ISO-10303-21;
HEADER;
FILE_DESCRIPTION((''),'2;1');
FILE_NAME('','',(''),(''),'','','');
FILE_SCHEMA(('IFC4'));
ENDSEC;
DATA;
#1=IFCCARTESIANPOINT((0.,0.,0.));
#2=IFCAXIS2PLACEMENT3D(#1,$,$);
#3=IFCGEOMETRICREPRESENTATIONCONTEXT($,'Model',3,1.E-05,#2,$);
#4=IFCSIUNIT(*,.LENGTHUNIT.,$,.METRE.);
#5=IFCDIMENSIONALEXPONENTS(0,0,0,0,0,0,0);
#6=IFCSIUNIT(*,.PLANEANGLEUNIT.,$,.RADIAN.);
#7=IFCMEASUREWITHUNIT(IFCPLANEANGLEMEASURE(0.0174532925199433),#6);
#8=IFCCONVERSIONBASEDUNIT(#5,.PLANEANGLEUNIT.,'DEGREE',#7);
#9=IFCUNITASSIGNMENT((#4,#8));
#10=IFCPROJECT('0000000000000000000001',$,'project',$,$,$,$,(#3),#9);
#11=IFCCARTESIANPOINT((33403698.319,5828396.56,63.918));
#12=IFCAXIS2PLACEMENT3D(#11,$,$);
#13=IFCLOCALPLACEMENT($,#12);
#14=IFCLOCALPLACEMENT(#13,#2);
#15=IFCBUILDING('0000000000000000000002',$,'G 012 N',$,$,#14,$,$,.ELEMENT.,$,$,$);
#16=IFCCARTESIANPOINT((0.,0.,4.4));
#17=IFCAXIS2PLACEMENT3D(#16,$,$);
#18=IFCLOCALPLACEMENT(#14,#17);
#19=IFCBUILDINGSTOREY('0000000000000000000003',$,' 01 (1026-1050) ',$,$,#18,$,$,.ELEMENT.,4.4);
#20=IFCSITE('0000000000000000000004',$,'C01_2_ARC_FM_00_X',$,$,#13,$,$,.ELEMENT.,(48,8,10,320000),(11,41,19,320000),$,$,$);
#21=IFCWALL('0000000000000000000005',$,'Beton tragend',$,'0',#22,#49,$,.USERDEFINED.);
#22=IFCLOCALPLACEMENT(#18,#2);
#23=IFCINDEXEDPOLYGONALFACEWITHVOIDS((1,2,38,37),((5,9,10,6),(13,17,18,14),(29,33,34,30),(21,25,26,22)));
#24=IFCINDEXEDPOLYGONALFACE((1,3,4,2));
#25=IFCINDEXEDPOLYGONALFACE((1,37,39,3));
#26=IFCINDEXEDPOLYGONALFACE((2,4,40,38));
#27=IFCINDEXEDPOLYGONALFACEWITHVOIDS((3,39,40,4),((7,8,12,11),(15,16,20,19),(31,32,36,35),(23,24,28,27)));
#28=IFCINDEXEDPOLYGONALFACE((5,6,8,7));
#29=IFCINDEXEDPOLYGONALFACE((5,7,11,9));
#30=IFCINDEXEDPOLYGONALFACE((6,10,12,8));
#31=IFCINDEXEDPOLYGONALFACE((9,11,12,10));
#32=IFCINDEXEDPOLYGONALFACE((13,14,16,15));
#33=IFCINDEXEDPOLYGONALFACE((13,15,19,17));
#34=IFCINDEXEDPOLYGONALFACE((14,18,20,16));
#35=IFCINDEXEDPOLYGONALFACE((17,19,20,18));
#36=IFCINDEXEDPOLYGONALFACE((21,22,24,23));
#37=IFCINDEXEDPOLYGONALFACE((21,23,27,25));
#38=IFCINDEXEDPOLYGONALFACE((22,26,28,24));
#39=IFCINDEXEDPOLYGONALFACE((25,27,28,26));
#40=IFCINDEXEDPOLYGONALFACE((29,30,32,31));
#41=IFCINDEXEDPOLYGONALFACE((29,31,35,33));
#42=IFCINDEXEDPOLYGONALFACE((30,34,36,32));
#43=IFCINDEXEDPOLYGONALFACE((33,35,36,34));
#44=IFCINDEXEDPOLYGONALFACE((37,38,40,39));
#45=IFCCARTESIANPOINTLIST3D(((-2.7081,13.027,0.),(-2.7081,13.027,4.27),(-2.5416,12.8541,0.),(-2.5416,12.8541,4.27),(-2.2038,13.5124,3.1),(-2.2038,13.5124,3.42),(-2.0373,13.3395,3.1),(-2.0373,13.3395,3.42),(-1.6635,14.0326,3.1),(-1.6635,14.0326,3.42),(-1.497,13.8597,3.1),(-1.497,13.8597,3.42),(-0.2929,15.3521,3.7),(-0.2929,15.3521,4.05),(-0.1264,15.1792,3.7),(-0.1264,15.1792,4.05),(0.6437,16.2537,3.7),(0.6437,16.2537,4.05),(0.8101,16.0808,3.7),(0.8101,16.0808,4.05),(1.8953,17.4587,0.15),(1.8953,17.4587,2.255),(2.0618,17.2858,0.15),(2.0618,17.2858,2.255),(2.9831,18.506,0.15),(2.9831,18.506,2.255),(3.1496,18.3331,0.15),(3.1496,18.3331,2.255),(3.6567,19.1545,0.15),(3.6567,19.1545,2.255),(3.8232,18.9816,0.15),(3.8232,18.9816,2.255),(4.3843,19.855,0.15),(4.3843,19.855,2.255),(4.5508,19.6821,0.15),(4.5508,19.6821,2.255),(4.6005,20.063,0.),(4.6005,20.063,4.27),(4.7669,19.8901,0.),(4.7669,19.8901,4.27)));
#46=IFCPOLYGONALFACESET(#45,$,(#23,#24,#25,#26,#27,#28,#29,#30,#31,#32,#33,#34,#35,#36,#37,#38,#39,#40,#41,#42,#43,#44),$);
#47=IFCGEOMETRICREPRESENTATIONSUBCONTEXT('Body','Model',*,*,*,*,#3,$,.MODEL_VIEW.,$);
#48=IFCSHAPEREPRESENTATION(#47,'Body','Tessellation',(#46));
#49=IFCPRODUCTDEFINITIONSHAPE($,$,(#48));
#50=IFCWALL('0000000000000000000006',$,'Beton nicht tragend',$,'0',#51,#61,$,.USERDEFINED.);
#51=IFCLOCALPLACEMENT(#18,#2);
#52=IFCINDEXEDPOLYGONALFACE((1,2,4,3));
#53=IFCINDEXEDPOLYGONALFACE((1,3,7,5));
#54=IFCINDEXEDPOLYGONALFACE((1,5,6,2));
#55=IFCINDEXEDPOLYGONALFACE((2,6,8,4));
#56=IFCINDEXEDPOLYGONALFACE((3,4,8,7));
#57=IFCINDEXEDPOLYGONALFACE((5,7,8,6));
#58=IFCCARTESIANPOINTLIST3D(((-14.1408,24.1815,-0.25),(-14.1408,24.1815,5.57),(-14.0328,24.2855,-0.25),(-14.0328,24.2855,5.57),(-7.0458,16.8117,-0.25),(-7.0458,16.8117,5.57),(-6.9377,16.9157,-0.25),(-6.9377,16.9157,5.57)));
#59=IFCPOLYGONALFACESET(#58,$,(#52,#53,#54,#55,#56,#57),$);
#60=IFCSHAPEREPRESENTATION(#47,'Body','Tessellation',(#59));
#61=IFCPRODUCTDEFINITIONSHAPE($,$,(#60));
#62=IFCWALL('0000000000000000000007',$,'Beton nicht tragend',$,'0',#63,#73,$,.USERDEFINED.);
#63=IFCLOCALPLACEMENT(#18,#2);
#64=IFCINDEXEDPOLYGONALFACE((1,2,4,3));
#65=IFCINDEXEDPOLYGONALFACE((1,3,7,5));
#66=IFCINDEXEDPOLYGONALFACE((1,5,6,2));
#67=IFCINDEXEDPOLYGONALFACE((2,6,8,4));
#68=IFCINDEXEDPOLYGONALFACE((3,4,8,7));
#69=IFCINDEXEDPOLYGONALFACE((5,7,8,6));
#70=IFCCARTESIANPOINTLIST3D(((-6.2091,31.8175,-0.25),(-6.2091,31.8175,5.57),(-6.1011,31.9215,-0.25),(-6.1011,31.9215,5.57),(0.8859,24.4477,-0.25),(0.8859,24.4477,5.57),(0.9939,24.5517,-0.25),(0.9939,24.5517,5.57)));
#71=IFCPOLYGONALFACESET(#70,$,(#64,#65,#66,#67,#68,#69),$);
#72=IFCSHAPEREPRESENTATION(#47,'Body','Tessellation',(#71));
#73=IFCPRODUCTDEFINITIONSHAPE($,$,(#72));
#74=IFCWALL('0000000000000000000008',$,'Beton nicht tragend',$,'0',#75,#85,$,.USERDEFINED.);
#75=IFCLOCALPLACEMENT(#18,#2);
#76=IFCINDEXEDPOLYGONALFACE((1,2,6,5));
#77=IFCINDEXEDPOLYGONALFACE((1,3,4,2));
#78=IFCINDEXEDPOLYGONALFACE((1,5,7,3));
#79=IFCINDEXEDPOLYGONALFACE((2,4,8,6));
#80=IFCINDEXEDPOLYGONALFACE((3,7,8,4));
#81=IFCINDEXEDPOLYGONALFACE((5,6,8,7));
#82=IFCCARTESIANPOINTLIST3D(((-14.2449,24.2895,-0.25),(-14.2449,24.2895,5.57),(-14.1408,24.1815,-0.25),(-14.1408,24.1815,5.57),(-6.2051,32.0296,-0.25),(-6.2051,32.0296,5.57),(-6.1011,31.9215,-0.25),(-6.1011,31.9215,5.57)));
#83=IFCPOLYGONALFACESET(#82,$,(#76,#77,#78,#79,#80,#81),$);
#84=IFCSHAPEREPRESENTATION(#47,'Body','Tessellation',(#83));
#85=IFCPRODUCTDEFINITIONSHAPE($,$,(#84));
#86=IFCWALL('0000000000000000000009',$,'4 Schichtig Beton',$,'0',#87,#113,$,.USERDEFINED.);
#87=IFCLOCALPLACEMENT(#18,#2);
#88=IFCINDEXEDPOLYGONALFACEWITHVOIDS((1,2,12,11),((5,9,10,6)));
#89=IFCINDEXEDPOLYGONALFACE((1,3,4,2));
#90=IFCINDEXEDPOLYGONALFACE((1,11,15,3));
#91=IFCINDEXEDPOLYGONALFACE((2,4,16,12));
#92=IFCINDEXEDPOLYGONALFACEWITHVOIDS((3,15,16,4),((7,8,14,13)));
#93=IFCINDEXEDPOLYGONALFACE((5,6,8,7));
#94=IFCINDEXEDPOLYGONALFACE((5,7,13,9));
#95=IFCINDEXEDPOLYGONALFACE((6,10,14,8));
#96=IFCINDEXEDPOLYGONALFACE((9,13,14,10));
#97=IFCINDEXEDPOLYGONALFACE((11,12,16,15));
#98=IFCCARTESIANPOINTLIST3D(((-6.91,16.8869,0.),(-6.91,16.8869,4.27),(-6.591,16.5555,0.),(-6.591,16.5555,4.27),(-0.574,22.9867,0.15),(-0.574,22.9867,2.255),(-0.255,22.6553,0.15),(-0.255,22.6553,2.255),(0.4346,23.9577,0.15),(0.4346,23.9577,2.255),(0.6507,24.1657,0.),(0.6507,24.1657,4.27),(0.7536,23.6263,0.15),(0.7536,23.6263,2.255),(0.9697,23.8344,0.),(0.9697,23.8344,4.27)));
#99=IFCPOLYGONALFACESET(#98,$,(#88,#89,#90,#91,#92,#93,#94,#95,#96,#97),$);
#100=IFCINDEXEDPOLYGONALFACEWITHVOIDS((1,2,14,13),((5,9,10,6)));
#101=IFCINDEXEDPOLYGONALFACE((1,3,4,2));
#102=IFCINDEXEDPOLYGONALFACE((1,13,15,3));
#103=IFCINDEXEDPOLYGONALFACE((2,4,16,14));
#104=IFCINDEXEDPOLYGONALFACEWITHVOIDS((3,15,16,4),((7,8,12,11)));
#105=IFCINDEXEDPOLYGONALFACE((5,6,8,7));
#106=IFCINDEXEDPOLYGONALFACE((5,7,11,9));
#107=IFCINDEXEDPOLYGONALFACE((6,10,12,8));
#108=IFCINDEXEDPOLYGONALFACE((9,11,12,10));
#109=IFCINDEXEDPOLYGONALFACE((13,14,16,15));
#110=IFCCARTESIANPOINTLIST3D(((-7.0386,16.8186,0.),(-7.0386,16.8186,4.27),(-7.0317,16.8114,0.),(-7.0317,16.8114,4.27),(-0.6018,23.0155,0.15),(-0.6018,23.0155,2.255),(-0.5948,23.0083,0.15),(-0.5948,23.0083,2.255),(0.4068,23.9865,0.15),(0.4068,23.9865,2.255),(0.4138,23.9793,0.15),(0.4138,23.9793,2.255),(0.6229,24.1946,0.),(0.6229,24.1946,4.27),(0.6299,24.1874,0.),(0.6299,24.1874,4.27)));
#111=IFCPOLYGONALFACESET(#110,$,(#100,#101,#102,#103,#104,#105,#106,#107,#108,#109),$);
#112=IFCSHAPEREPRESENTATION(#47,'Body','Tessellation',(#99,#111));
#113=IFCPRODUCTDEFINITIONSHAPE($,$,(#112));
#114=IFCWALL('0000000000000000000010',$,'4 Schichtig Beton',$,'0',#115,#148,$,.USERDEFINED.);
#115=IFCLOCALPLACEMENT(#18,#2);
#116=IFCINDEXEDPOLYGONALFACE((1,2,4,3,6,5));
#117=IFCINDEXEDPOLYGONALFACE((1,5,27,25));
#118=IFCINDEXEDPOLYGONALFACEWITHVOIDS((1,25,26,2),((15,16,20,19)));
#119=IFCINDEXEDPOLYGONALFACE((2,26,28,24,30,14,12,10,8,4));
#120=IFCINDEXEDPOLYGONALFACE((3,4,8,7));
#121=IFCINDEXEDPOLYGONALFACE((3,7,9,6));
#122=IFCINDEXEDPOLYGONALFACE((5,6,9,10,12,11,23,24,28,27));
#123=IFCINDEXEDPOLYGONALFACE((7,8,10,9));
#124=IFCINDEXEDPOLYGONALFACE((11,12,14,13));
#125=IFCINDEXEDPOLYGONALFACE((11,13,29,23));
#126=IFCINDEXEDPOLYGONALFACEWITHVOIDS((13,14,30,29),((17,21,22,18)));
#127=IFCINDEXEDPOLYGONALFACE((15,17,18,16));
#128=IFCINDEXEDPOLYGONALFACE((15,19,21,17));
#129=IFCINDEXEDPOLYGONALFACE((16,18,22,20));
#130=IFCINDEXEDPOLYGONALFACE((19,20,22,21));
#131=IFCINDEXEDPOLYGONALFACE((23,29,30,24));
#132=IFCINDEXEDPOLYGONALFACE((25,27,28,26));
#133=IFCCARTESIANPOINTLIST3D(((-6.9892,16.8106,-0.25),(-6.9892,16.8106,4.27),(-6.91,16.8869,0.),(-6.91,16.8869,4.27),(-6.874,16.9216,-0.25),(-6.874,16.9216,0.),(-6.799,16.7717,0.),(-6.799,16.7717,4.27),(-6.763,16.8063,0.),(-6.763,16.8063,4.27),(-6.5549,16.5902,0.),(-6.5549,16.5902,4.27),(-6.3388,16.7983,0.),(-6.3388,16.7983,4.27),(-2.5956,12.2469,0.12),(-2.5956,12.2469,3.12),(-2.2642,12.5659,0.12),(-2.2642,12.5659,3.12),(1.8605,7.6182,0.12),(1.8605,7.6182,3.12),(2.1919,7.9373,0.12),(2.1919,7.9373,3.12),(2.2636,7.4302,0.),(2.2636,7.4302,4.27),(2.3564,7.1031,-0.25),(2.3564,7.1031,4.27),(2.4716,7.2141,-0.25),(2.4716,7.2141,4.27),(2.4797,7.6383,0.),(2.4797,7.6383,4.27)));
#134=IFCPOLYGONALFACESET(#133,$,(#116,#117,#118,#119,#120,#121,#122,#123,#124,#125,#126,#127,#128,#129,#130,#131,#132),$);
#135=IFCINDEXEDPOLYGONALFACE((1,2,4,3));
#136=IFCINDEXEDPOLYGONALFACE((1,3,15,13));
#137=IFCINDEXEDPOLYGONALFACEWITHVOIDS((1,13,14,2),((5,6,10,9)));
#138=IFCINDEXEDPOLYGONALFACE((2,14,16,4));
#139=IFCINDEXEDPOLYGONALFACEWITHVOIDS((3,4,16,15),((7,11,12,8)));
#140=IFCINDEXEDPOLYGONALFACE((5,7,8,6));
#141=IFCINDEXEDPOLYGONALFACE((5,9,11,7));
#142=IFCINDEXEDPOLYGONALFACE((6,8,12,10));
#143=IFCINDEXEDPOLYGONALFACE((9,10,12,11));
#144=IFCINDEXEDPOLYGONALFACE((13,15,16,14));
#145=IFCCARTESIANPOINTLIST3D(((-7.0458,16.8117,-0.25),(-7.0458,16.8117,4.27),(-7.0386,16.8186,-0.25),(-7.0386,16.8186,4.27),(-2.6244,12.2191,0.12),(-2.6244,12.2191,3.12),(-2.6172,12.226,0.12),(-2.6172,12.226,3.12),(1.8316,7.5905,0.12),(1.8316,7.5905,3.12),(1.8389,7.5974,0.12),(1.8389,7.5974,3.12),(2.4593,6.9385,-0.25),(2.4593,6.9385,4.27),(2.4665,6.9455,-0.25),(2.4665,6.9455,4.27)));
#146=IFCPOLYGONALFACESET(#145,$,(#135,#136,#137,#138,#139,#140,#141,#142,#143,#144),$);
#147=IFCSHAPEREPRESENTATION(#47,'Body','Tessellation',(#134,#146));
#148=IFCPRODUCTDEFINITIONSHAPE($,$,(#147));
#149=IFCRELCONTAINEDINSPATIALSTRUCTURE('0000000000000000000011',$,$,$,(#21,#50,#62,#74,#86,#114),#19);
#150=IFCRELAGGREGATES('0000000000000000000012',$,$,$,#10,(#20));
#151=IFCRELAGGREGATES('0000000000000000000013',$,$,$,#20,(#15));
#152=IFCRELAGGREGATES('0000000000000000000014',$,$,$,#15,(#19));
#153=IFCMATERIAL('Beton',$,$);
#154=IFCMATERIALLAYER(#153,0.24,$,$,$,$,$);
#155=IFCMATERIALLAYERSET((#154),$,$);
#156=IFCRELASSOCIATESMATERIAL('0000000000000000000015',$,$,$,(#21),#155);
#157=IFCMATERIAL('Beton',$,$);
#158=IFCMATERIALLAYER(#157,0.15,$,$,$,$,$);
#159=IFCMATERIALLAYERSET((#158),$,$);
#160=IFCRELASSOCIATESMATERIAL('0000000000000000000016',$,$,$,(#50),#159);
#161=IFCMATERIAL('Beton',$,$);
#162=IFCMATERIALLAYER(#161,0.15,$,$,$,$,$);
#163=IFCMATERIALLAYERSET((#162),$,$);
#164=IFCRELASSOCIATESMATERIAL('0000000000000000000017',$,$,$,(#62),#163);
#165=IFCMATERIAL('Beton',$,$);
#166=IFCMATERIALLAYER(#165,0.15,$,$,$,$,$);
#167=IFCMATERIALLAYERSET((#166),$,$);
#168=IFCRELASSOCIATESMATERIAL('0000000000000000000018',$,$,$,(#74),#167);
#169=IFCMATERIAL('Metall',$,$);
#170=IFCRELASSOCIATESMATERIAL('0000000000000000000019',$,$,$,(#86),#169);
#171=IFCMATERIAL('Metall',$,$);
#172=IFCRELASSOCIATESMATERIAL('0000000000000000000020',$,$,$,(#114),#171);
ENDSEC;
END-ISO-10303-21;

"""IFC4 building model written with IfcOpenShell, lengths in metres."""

from ifc_helpers import new_model, entity, si_unit, converted_unit, frame, frame_2d, origin, origin_with_axes, place, context, subcontext, project, spatial, polyline, rectangle, outline, extrude, clip, bounded_halfspace, material, layer, layer_set, layer_usage, element, save


model = new_model("IFC4")

# Units and contexts
model_context = context("Model", 3, precision=1e-05, world=origin())
body_context = subcontext(model_context, "Body", "Model", "MODEL_VIEW")
ifc_project = project(units=[si_unit("LENGTHUNIT", "METRE"), converted_unit("PLANEANGLEUNIT", "DEGREE", entity("IfcPlaneAngleMeasure", 0.0174532925199433), si_unit("PLANEANGLEUNIT", "RADIAN"), dimensions=[0, 0, 0, 0, 0, 0, 0])], contexts=[model_context])

# Site, building, storey
site_placement = place(None, frame((33403698.319, 5828396.56, 63.918)))
site = spatial("IfcSite", under=ifc_project, at=site_placement, Name="C01_2_ARC_FM_00_X", CompositionType="ELEMENT", RefLatitude=(48, 8, 10, 320000), RefLongitude=(11, 41, 19, 320000))
building_placement = place(site_placement, origin())
building = spatial("IfcBuilding", under=site, at=building_placement, Name="G 012 N", CompositionType="ELEMENT")
storey_placement = place(building_placement, frame((0.0, 0.0, 4.4)))
storey = spatial("IfcBuildingStorey", under=building, at=storey_placement, Name=" 01 (1026-1050) ", CompositionType="ELEMENT", Elevation=4.4)

# Wall, openings
ifc_material_1 = material(Name="Beton")
ifc_layer_1 = layer(ifc_material_1, 0.24)
ifc_layer_set_1 = layer_set([ifc_layer_1])
ifc_layer_usage_1 = layer_usage(ifc_layer_set_1, "AXIS2", "POSITIVE", 0.0)
wall_1_placement = place(storey_placement, frame((4.6005, 20.063, 0.0), z_axis=(0.0, 0.0, 1.0), x_axis=(-0.720408, -0.693551, 0.0)))
wall_1 = element("IfcWall", 1, at=wall_1_placement, inside=storey, material=ifc_layer_usage_1, Name="Beton tragend", ObjectType="0", PredefinedType="USERDEFINED", context=body_context, shape_type="SweptSolid", body=[
    extrude(rectangle(XDim=10.145, YDim=0.24, at=frame_2d((5.0725, 0.12), x_axis=(1.0, 0.0))), origin_with_axes(), (0.0, 0.0, 1.0), 4.27),
])
opening_1_placement = place(wall_1_placement, frame((8.695, 0.0, 3.1), z_axis=(0.0, 1.0, 0.0), x_axis=(0.0, 0.0, 1.0)))
element("IfcOpeningElement", 2, at=opening_1_placement, cuts=wall_1, ObjectType="0", PredefinedType="USERDEFINED", context=body_context, shape_type="SweptSolid", body=[
    extrude(outline(polyline([(0.0, 0.75), (0.32, 0.75), (0.32, 0.0), (0.0, 0.0), (0.0, 0.75)])), origin_with_axes(), (0.0, 0.0, 1.0), 0.24),
])
opening_2_placement = place(wall_1_placement, frame((6.7924, 0.24, 3.7), z_axis=(0.0, -1.0, 0.0), x_axis=(0.0, 0.0, 1.0)))
element("IfcOpeningElement", 3, at=opening_2_placement, cuts=wall_1, ObjectType="0", PredefinedType="USERDEFINED", context=body_context, shape_type="SweptSolid", body=[
    extrude(outline(polyline([(0.0, 1.3), (0.35, 1.3), (0.35, 0.0), (0.0, 0.0), (0.0, 1.3)])), origin_with_axes(), (0.0, 0.0, 1.0), 0.24),
])
opening_3_placement = place(wall_1_placement, frame((2.245, 0.0, 0.15), z_axis=(0.0, 1.0, 0.0), x_axis=(0.0, 0.0, 1.0)))
element("IfcOpeningElement", 4, at=opening_3_placement, cuts=wall_1, ObjectType="Opening", context=body_context, shape_type="SweptSolid", body=[
    extrude(outline(polyline([(0.0, 1.51), (2.105, 1.51), (2.105, 0.0), (0.0, 0.0), (0.0, 1.51)])), origin_with_axes(), (0.0, 0.0, 1.0), 0.24),
])
opening_4_placement = place(wall_1_placement, frame((1.31, 0.24, 0.15), z_axis=(0.0, -1.0, 0.0), x_axis=(0.0, 0.0, 1.0)))
element("IfcOpeningElement", 5, at=opening_4_placement, cuts=wall_1, ObjectType="Opening", context=body_context, shape_type="SweptSolid", body=[
    extrude(outline(polyline([(0.0, 1.01), (2.105, 1.01), (2.105, 0.0), (0.0, 0.0), (0.0, 1.01)])), origin_with_axes(), (0.0, 0.0, 1.0), 0.24),
])

# Walls
ifc_material_2 = material(Name="Beton")
ifc_layer_2 = layer(ifc_material_2, 0.15)
ifc_layer_set_2 = layer_set([ifc_layer_2])
ifc_layer_usage_2 = layer_usage(ifc_layer_set_2, "AXIS2", "POSITIVE", 0.0)
wall_2_placement = place(storey_placement, frame((-14.1408, 24.1815, -0.25), z_axis=(0.0, 0.0, 1.0), x_axis=(0.693551, -0.720408, 0.0)))
element("IfcWall", 6, at=wall_2_placement, inside=storey, material=ifc_layer_usage_2, Name="Beton nicht tragend", ObjectType="0", PredefinedType="USERDEFINED", context=body_context, shape_type="SweptSolid", body=[
    extrude(rectangle(XDim=10.23, YDim=0.15, at=frame_2d((5.115, 0.075), x_axis=(1.0, 0.0))), origin_with_axes(), (0.0, 0.0, 1.0), 5.82),
])
ifc_material_3 = material(Name="Beton")
ifc_layer_3 = layer(ifc_material_3, 0.15)
ifc_layer_set_3 = layer_set([ifc_layer_3])
ifc_layer_usage_3 = layer_usage(ifc_layer_set_3, "AXIS2", "POSITIVE", 0.0)
wall_3_placement = place(storey_placement, frame((0.9939, 24.5517, -0.25), z_axis=(0.0, 0.0, 1.0), x_axis=(-0.693551, 0.720408, 0.0)))
element("IfcWall", 7, at=wall_3_placement, inside=storey, material=ifc_layer_usage_3, Name="Beton nicht tragend", ObjectType="0", PredefinedType="USERDEFINED", context=body_context, shape_type="SweptSolid", body=[
    extrude(rectangle(XDim=10.23, YDim=0.15, at=frame_2d((5.115, 0.075), x_axis=(1.0, 0.0))), origin_with_axes(), (0.0, 0.0, 1.0), 5.82),
])
ifc_material_4 = material(Name="Beton")
ifc_layer_4 = layer(ifc_material_4, 0.15)
ifc_layer_set_4 = layer_set([ifc_layer_4])
ifc_layer_usage_4 = layer_usage(ifc_layer_set_4, "AXIS2", "POSITIVE", 0.0)
wall_4_placement = place(storey_placement, frame((-6.2051, 32.0296, -0.25), z_axis=(0.0, 0.0, 1.0), x_axis=(-0.720408, -0.693551, 0.0)))
element("IfcWall", 8, at=wall_4_placement, inside=storey, material=ifc_layer_usage_4, Name="Beton nicht tragend", ObjectType="0", PredefinedType="USERDEFINED", context=body_context, shape_type="SweptSolid", body=[
    extrude(rectangle(XDim=11.16, YDim=0.15, at=frame_2d((5.58, 0.075), x_axis=(1.0, 0.0))), origin_with_axes(), (0.0, 0.0, 1.0), 5.82),
])

# Walls, openings
ifc_material_5 = material(Name="Metall")
wall_5_placement = place(storey_placement, frame((0.6229, 24.1946, 0.0), z_axis=(0.0, 0.0, 1.0), x_axis=(-0.720408, -0.693551, 0.0)))
wall_5 = element("IfcWall", 9, at=wall_5_placement, inside=storey, material=ifc_material_5, Name="4 Schichtig Beton", ObjectType="0", PredefinedType="USERDEFINED", context=body_context, shape_type="SweptSolid", body=[
    extrude(rectangle(XDim=10.495, YDim=0.46, at=frame_2d((-5.2475, -0.23), x_axis=(-1.0, 0.0))), frame((10.495, 0.5, 0.0), z_axis=(0.0, 0.0, 1.0), x_axis=(1.0, 0.0, 0.0)), (0.0, 0.0, 1.0), 4.27),
    extrude(rectangle(XDim=10.635, YDim=0.01, at=frame_2d((-5.3175, -0.005), x_axis=(-1.0, 0.0))), frame((10.635, 0.01, 0.0), z_axis=(0.0, 0.0, 1.0), x_axis=(1.0, 0.0, 0.0)), (0.0, 0.0, 1.0), 4.27),
])
opening_5_placement = place(wall_5_placement, frame((1.7, 0.01, 0.15), z_axis=(0.0, -1.0, 0.0), x_axis=(0.0, 0.0, 1.0)))
element("IfcOpeningElement", 10, at=opening_5_placement, cuts=wall_5, ObjectType="0", PredefinedType="USERDEFINED", context=body_context, shape_type="SweptSolid", body=[
    extrude(outline(polyline([(0.0, 1.4), (2.105, 1.4), (2.105, 0.0), (0.0, 0.0), (0.0, 1.4)])), origin_with_axes(), (0.0, 0.0, 1.0), 0.01),
    extrude(outline(polyline([(0.0, 1.4), (2.105, 1.4), (2.105, 0.0), (0.0, 0.0), (0.0, 1.4)])), frame((0.0, 0.0, -0.03), z_axis=(0.0, 0.0, 1.0), x_axis=(1.0, 0.0, 0.0)), (0.0, 0.0, 1.0), 0.03),
    extrude(outline(polyline([(0.0, 1.4), (2.105, 1.4), (2.105, 0.0), (0.0, 0.0), (0.0, 1.4)])), frame((0.0, 0.0, -0.19), z_axis=(0.0, 0.0, 1.0), x_axis=(1.0, 0.0, 0.0)), (0.0, 0.0, 1.0), 0.16),
    extrude(outline(polyline([(0.0, 1.4), (2.105, 1.4), (2.105, 0.0), (0.0, 0.0), (0.0, 1.4)])), frame((0.0, 0.0, -0.49), z_axis=(0.0, 0.0, 1.0), x_axis=(1.0, 0.0, 0.0)), (0.0, 0.0, 1.0), 0.3),
])
ifc_material_6 = material(Name="Metall")
wall_6_placement = place(storey_placement, frame((-7.0458, 16.8117, -0.25), z_axis=(0.0, 0.0, 1.0), x_axis=(0.693551, -0.720408, 0.0)))
wall_6 = element("IfcWall", 11, at=wall_6_placement, inside=storey, material=ifc_material_6, Name="4 Schichtig Beton", ObjectType="0", PredefinedType="USERDEFINED", context=body_context, shape_type="Clipping", body=[
    clip(clip(extrude(outline(polyline([(6.1816, 6.8926), (6.1816, 7.1926), (-6.5334, 7.1926), (-6.5334, 6.8926), (-6.9934, 6.8926), (-6.9934, 6.7326), (6.4816, 6.7326), (6.4816, 6.8926), (6.1816, 6.8926)])), frame((7.0334, -6.6926, 0.0), z_axis=(0.0, 0.0, 1.0), x_axis=(1.0, 0.0, 0.0)), (0.0, 0.0, 1.0), 4.52), bounded_halfspace(frame((6.8575, 0.35, 0.25), z_axis=(0.0, 0.0, 1.0), x_axis=(0.0, -1.0, 0.0)), True, origin_with_axes(), polyline([(0.5, 0.5), (0.5, 0.2), (13.215, 0.2), (13.215, 0.5), (0.5, 0.5)]))), bounded_halfspace(frame((0.12, 0.175, 0.25), z_axis=(0.0, 0.0, -1.0), x_axis=(-1.0, 0.0, 0.0)), True, origin_with_axes(), polyline([(0.2, 0.2), (0.04, 0.2), (0.04, 0.15), (0.2, 0.15), (0.2, 0.2)]))),
    clip(clip(extrude(rectangle(XDim=13.705, YDim=0.01, at=frame_2d((-6.8525, -0.005), x_axis=(-1.0, 0.0))), frame((13.705, 0.01, 0.0), z_axis=(0.0, 0.0, 1.0), x_axis=(1.0, 0.0, 0.0)), (0.0, 0.0, 1.0), 4.52), bounded_halfspace(frame((6.8575, 0.35, 0.25), z_axis=(0.0, 0.0, 1.0), x_axis=(0.0, -1.0, 0.0)), True, origin_with_axes(), polyline([(0.5, 0.5), (0.5, 0.2), (13.215, 0.2), (13.215, 0.5), (0.5, 0.5)]))), bounded_halfspace(frame((0.12, 0.175, 0.25), z_axis=(0.0, 0.0, -1.0), x_axis=(-1.0, 0.0, 0.0)), True, origin_with_axes(), polyline([(0.2, 0.2), (0.04, 0.2), (0.04, 0.15), (0.2, 0.15), (0.2, 0.2)]))),
])
opening_6_placement = place(wall_6_placement, frame((12.8, 0.01, 0.37), z_axis=(0.0, -1.0, 0.0), x_axis=(0.0, 0.0, 1.0)))
element("IfcOpeningElement", 12, at=opening_6_placement, cuts=wall_6, ObjectType="Opening", context=body_context, shape_type="SweptSolid", body=[
    extrude(outline(polyline([(0.0, 6.425), (3.0, 6.425), (3.0, 0.0), (0.0, 0.0), (0.0, 6.425)])), origin_with_axes(), (0.0, 0.0, 1.0), 0.01),
    extrude(outline(polyline([(0.0, 6.425), (3.0, 6.425), (3.0, 0.0), (0.0, 0.0), (0.0, 6.425)])), frame((0.0, 0.0, -0.03), z_axis=(0.0, 0.0, 1.0), x_axis=(1.0, 0.0, 0.0)), (0.0, 0.0, 1.0), 0.03),
    extrude(outline(polyline([(0.0, 6.425), (3.0, 6.425), (3.0, 0.0), (0.0, 0.0), (0.0, 6.425)])), frame((0.0, 0.0, -0.19), z_axis=(0.0, 0.0, 1.0), x_axis=(1.0, 0.0, 0.0)), (0.0, 0.0, 1.0), 0.16),
    extrude(outline(polyline([(0.0, 6.425), (3.0, 6.425), (3.0, 0.0), (0.0, 0.0), (0.0, 6.425)])), frame((0.0, 0.0, -0.49), z_axis=(0.0, 0.0, 1.0), x_axis=(1.0, 0.0, 0.0)), (0.0, 0.0, 1.0), 0.3),
])

save(model, "model.ifc")
